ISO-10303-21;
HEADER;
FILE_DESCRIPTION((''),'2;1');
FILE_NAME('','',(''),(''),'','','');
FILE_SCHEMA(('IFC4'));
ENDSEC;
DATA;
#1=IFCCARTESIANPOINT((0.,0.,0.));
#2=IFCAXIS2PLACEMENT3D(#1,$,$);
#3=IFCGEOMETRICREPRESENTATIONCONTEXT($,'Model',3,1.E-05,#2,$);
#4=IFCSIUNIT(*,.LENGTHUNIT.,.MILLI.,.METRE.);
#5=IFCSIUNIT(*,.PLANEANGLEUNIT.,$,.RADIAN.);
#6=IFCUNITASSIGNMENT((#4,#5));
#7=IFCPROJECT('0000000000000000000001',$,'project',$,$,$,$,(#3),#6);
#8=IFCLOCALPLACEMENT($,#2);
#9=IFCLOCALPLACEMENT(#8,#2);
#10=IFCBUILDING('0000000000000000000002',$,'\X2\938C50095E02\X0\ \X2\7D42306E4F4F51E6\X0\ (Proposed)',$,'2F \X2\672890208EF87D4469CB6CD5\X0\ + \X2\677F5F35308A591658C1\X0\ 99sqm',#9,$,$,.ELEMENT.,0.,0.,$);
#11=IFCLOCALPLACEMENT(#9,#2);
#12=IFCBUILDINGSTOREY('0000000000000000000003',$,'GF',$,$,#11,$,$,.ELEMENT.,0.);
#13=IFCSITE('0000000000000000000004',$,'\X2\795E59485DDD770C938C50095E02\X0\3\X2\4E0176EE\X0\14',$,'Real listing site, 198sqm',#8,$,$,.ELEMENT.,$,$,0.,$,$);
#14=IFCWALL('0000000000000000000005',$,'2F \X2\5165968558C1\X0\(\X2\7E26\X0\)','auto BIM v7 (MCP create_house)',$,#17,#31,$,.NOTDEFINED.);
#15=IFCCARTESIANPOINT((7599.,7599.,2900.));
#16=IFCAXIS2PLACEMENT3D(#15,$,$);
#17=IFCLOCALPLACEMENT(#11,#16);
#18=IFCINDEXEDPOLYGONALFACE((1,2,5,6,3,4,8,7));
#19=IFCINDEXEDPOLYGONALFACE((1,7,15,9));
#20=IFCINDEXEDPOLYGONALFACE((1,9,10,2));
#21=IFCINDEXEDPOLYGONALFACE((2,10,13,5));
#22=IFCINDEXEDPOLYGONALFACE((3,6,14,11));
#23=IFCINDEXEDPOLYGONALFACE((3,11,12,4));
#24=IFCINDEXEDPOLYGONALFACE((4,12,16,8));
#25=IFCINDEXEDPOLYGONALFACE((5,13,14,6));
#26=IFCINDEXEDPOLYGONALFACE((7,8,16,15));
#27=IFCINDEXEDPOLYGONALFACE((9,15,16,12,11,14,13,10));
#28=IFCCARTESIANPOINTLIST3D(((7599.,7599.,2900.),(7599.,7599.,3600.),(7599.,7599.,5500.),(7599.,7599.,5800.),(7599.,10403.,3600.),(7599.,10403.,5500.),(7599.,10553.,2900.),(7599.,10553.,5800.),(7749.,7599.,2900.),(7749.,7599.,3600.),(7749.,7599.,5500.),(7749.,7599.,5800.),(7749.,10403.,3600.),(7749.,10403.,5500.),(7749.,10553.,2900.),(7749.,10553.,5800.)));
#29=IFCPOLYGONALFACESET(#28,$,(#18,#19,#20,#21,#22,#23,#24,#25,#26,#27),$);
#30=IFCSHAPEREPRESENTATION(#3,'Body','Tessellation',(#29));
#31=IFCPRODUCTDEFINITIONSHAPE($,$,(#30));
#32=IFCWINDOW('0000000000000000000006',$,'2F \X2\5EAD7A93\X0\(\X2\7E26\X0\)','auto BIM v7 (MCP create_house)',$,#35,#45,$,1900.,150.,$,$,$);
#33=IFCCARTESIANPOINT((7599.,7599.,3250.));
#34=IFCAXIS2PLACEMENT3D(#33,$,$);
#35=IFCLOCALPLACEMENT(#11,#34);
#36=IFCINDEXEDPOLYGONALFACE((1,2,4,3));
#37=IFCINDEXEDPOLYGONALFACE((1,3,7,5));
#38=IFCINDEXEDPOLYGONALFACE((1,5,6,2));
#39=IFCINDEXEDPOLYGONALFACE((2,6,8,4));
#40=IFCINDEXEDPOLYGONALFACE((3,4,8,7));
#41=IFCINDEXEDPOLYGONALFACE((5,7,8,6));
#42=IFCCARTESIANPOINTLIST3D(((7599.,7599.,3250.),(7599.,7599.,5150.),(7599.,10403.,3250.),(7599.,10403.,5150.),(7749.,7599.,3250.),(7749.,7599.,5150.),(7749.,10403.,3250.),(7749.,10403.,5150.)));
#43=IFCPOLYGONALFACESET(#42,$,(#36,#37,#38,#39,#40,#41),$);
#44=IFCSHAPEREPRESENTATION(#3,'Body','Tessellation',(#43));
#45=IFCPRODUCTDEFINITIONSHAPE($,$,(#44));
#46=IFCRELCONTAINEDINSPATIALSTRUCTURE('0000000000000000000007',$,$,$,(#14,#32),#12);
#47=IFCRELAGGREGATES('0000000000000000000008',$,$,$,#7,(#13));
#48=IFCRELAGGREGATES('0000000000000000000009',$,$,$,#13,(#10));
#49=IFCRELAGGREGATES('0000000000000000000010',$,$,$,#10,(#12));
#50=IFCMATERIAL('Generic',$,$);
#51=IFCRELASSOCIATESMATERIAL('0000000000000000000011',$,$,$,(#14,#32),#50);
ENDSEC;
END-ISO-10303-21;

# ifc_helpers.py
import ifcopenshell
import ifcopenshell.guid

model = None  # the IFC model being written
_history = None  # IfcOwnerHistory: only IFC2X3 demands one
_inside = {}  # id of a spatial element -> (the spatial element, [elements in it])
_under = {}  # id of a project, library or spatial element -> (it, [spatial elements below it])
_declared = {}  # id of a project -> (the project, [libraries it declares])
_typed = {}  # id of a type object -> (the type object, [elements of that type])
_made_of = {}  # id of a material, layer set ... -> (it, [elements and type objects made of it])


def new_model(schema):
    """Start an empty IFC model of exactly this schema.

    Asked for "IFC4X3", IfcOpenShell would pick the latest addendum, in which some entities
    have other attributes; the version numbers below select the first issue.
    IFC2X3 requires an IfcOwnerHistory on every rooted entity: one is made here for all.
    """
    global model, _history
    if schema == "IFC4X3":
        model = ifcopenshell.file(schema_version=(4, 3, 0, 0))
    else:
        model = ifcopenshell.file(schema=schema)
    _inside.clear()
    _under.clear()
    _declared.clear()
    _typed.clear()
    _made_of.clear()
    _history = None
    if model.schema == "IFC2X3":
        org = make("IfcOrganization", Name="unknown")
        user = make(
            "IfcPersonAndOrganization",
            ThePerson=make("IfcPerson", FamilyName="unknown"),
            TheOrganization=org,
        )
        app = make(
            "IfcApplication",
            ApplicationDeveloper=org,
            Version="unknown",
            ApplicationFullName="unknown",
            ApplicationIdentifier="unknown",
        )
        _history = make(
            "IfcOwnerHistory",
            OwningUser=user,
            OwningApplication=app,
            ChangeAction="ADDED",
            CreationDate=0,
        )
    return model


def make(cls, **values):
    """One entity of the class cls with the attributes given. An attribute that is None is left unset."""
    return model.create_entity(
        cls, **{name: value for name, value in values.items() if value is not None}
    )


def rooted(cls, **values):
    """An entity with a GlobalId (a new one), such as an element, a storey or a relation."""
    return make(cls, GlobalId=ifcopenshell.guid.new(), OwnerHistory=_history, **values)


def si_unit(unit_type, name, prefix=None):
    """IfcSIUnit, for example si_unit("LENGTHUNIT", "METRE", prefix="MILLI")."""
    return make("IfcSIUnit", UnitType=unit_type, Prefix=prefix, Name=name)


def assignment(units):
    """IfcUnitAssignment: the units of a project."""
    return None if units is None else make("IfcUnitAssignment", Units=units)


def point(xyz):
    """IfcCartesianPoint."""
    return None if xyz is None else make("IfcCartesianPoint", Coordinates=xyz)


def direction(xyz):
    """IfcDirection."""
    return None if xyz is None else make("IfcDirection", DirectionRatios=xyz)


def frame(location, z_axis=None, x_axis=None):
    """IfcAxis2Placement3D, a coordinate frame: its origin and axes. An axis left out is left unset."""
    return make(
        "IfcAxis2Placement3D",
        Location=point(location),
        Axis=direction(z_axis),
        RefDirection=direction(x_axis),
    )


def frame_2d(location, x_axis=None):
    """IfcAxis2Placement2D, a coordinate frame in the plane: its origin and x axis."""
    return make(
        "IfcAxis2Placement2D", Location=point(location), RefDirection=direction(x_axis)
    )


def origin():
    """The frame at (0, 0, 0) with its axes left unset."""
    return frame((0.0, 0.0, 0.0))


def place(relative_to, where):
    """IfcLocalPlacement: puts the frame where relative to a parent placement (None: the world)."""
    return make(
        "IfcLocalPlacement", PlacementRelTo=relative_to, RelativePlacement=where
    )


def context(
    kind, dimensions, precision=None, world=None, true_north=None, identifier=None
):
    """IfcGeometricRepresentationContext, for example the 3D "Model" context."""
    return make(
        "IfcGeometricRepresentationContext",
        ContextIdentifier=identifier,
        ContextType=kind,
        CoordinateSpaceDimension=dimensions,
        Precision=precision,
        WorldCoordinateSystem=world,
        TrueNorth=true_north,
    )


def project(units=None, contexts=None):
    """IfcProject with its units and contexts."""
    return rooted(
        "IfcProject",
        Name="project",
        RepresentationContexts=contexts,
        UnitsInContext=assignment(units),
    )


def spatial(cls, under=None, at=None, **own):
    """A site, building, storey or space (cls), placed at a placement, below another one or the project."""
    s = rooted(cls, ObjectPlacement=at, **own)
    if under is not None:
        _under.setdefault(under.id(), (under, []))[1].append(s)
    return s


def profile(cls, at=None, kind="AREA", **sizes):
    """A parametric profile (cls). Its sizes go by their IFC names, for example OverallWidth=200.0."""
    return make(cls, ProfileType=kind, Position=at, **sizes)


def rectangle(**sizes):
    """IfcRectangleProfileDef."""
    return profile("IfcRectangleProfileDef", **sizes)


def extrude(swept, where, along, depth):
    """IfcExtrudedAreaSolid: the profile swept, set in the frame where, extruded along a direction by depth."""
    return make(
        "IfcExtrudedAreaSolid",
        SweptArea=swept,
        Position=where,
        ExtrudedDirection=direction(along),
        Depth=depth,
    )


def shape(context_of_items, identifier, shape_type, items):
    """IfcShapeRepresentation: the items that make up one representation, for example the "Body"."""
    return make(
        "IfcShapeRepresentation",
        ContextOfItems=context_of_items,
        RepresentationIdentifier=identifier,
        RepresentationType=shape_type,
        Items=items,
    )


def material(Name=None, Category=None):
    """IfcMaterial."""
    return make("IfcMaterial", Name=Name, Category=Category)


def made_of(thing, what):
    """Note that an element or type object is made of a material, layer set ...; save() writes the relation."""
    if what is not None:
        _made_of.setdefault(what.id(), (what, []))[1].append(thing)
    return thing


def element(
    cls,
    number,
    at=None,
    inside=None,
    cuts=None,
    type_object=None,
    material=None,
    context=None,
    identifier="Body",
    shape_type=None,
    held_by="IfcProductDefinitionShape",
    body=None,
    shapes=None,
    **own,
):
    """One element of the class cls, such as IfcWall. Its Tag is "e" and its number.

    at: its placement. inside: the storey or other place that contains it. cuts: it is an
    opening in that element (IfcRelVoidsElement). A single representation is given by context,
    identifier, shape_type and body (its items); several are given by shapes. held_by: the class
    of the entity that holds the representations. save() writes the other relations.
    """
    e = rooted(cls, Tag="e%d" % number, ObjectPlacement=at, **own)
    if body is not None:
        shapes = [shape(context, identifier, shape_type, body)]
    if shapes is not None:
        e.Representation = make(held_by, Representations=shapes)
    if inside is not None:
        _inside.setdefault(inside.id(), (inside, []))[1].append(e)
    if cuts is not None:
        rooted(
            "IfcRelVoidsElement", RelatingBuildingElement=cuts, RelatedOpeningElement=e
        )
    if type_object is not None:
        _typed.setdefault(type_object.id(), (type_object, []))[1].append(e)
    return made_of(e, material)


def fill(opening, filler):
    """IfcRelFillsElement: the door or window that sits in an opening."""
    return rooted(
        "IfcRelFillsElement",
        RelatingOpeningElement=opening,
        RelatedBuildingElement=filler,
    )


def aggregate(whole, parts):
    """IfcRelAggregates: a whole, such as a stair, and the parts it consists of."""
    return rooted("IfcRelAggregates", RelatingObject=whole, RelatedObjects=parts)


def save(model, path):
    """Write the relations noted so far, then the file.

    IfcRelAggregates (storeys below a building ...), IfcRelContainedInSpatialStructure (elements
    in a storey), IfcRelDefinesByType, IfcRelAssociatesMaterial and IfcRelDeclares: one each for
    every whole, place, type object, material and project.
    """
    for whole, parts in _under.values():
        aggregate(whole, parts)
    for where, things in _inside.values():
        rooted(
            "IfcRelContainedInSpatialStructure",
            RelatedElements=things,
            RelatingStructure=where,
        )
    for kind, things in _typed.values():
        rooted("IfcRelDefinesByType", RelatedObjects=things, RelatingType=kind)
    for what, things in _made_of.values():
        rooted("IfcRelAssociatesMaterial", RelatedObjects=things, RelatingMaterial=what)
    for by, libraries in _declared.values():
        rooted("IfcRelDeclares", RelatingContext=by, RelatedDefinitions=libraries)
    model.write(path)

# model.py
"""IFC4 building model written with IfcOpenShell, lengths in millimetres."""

from ifc_helpers import new_model, si_unit, frame, frame_2d, origin, place, context, project, spatial, rectangle, extrude, material, element, fill, save


model = new_model("IFC4")

# Units and contexts
model_context = context("Model", 3, precision=1e-05, world=origin())
ifc_project = project(units=[si_unit("LENGTHUNIT", "METRE", prefix="MILLI"), si_unit("PLANEANGLEUNIT", "RADIAN")], contexts=[model_context])

# Site, building, storey
site_placement = place(None, origin())
site = spatial("IfcSite", under=ifc_project, at=site_placement, Name="神奈川県鎌倉市3丁目14", ObjectType="Real listing site, 198sqm", CompositionType="ELEMENT", RefElevation=0.0)
building_placement = place(site_placement, origin())
building = spatial("IfcBuilding", under=site, at=building_placement, Name="鎌倉市 終の住処 (Proposed)", ObjectType="2F 木造軸組構法 + 板張り外壁 99sqm", CompositionType="ELEMENT", ElevationOfRefHeight=0.0, ElevationOfTerrain=0.0)
storey_placement = place(building_placement, origin())
storey = spatial("IfcBuildingStorey", under=building, at=storey_placement, Name="GF", CompositionType="ELEMENT", Elevation=0.0)

# Shared definitions
ifc_material = material(Name="Generic")

# Wall, opening, window
wall_1_placement = place(storey_placement, frame((7599.0, 7599.0, 2900.0)))
wall_1 = element("IfcWall", 1, at=wall_1_placement, inside=storey, material=ifc_material, Name="2F 入隅壁(縦)", Description="auto BIM v7 (MCP create_house)", PredefinedType="NOTDEFINED", context=model_context, shape_type="SweptSolid", body=[
    extrude(rectangle(XDim=150.0, YDim=2954.0, at=frame_2d((75.0, 1477.0))), frame((7599.0, 7599.0, 2900.0)), (0.0, 0.0, 1.0), 2900.0),
])
opening_1_placement = place(storey_placement, frame((7599.0, 7599.0, 3250.0)))
opening_1 = element("IfcOpeningElement", 2, at=opening_1_placement, cuts=wall_1, PredefinedType="NOTDEFINED", context=model_context, shape_type="SweptSolid", body=[
    extrude(rectangle(XDim=150.0, YDim=2804.0, at=frame_2d((75.0, 1402.0))), frame((7599.0, 7599.0, 3250.0)), (0.0, 0.0, 1.0), 1900.0),
])
window_1_placement = place(storey_placement, frame((7599.0, 7599.0, 3250.0)))
window_1 = element("IfcWindow", 3, at=window_1_placement, inside=storey, material=ifc_material, Name="2F 庭窓(縦)", Description="auto BIM v7 (MCP create_house)", OverallHeight=1900.0, OverallWidth=150.0, context=model_context, shape_type="SweptSolid", body=[
    extrude(rectangle(XDim=150.0, YDim=2804.0, at=frame_2d((75.0, 1402.0))), frame((7599.0, 7599.0, 3250.0)), (0.0, 0.0, 1.0), 1900.0),
])
fill(opening_1, window_1)

save(model, "model.ifc")
